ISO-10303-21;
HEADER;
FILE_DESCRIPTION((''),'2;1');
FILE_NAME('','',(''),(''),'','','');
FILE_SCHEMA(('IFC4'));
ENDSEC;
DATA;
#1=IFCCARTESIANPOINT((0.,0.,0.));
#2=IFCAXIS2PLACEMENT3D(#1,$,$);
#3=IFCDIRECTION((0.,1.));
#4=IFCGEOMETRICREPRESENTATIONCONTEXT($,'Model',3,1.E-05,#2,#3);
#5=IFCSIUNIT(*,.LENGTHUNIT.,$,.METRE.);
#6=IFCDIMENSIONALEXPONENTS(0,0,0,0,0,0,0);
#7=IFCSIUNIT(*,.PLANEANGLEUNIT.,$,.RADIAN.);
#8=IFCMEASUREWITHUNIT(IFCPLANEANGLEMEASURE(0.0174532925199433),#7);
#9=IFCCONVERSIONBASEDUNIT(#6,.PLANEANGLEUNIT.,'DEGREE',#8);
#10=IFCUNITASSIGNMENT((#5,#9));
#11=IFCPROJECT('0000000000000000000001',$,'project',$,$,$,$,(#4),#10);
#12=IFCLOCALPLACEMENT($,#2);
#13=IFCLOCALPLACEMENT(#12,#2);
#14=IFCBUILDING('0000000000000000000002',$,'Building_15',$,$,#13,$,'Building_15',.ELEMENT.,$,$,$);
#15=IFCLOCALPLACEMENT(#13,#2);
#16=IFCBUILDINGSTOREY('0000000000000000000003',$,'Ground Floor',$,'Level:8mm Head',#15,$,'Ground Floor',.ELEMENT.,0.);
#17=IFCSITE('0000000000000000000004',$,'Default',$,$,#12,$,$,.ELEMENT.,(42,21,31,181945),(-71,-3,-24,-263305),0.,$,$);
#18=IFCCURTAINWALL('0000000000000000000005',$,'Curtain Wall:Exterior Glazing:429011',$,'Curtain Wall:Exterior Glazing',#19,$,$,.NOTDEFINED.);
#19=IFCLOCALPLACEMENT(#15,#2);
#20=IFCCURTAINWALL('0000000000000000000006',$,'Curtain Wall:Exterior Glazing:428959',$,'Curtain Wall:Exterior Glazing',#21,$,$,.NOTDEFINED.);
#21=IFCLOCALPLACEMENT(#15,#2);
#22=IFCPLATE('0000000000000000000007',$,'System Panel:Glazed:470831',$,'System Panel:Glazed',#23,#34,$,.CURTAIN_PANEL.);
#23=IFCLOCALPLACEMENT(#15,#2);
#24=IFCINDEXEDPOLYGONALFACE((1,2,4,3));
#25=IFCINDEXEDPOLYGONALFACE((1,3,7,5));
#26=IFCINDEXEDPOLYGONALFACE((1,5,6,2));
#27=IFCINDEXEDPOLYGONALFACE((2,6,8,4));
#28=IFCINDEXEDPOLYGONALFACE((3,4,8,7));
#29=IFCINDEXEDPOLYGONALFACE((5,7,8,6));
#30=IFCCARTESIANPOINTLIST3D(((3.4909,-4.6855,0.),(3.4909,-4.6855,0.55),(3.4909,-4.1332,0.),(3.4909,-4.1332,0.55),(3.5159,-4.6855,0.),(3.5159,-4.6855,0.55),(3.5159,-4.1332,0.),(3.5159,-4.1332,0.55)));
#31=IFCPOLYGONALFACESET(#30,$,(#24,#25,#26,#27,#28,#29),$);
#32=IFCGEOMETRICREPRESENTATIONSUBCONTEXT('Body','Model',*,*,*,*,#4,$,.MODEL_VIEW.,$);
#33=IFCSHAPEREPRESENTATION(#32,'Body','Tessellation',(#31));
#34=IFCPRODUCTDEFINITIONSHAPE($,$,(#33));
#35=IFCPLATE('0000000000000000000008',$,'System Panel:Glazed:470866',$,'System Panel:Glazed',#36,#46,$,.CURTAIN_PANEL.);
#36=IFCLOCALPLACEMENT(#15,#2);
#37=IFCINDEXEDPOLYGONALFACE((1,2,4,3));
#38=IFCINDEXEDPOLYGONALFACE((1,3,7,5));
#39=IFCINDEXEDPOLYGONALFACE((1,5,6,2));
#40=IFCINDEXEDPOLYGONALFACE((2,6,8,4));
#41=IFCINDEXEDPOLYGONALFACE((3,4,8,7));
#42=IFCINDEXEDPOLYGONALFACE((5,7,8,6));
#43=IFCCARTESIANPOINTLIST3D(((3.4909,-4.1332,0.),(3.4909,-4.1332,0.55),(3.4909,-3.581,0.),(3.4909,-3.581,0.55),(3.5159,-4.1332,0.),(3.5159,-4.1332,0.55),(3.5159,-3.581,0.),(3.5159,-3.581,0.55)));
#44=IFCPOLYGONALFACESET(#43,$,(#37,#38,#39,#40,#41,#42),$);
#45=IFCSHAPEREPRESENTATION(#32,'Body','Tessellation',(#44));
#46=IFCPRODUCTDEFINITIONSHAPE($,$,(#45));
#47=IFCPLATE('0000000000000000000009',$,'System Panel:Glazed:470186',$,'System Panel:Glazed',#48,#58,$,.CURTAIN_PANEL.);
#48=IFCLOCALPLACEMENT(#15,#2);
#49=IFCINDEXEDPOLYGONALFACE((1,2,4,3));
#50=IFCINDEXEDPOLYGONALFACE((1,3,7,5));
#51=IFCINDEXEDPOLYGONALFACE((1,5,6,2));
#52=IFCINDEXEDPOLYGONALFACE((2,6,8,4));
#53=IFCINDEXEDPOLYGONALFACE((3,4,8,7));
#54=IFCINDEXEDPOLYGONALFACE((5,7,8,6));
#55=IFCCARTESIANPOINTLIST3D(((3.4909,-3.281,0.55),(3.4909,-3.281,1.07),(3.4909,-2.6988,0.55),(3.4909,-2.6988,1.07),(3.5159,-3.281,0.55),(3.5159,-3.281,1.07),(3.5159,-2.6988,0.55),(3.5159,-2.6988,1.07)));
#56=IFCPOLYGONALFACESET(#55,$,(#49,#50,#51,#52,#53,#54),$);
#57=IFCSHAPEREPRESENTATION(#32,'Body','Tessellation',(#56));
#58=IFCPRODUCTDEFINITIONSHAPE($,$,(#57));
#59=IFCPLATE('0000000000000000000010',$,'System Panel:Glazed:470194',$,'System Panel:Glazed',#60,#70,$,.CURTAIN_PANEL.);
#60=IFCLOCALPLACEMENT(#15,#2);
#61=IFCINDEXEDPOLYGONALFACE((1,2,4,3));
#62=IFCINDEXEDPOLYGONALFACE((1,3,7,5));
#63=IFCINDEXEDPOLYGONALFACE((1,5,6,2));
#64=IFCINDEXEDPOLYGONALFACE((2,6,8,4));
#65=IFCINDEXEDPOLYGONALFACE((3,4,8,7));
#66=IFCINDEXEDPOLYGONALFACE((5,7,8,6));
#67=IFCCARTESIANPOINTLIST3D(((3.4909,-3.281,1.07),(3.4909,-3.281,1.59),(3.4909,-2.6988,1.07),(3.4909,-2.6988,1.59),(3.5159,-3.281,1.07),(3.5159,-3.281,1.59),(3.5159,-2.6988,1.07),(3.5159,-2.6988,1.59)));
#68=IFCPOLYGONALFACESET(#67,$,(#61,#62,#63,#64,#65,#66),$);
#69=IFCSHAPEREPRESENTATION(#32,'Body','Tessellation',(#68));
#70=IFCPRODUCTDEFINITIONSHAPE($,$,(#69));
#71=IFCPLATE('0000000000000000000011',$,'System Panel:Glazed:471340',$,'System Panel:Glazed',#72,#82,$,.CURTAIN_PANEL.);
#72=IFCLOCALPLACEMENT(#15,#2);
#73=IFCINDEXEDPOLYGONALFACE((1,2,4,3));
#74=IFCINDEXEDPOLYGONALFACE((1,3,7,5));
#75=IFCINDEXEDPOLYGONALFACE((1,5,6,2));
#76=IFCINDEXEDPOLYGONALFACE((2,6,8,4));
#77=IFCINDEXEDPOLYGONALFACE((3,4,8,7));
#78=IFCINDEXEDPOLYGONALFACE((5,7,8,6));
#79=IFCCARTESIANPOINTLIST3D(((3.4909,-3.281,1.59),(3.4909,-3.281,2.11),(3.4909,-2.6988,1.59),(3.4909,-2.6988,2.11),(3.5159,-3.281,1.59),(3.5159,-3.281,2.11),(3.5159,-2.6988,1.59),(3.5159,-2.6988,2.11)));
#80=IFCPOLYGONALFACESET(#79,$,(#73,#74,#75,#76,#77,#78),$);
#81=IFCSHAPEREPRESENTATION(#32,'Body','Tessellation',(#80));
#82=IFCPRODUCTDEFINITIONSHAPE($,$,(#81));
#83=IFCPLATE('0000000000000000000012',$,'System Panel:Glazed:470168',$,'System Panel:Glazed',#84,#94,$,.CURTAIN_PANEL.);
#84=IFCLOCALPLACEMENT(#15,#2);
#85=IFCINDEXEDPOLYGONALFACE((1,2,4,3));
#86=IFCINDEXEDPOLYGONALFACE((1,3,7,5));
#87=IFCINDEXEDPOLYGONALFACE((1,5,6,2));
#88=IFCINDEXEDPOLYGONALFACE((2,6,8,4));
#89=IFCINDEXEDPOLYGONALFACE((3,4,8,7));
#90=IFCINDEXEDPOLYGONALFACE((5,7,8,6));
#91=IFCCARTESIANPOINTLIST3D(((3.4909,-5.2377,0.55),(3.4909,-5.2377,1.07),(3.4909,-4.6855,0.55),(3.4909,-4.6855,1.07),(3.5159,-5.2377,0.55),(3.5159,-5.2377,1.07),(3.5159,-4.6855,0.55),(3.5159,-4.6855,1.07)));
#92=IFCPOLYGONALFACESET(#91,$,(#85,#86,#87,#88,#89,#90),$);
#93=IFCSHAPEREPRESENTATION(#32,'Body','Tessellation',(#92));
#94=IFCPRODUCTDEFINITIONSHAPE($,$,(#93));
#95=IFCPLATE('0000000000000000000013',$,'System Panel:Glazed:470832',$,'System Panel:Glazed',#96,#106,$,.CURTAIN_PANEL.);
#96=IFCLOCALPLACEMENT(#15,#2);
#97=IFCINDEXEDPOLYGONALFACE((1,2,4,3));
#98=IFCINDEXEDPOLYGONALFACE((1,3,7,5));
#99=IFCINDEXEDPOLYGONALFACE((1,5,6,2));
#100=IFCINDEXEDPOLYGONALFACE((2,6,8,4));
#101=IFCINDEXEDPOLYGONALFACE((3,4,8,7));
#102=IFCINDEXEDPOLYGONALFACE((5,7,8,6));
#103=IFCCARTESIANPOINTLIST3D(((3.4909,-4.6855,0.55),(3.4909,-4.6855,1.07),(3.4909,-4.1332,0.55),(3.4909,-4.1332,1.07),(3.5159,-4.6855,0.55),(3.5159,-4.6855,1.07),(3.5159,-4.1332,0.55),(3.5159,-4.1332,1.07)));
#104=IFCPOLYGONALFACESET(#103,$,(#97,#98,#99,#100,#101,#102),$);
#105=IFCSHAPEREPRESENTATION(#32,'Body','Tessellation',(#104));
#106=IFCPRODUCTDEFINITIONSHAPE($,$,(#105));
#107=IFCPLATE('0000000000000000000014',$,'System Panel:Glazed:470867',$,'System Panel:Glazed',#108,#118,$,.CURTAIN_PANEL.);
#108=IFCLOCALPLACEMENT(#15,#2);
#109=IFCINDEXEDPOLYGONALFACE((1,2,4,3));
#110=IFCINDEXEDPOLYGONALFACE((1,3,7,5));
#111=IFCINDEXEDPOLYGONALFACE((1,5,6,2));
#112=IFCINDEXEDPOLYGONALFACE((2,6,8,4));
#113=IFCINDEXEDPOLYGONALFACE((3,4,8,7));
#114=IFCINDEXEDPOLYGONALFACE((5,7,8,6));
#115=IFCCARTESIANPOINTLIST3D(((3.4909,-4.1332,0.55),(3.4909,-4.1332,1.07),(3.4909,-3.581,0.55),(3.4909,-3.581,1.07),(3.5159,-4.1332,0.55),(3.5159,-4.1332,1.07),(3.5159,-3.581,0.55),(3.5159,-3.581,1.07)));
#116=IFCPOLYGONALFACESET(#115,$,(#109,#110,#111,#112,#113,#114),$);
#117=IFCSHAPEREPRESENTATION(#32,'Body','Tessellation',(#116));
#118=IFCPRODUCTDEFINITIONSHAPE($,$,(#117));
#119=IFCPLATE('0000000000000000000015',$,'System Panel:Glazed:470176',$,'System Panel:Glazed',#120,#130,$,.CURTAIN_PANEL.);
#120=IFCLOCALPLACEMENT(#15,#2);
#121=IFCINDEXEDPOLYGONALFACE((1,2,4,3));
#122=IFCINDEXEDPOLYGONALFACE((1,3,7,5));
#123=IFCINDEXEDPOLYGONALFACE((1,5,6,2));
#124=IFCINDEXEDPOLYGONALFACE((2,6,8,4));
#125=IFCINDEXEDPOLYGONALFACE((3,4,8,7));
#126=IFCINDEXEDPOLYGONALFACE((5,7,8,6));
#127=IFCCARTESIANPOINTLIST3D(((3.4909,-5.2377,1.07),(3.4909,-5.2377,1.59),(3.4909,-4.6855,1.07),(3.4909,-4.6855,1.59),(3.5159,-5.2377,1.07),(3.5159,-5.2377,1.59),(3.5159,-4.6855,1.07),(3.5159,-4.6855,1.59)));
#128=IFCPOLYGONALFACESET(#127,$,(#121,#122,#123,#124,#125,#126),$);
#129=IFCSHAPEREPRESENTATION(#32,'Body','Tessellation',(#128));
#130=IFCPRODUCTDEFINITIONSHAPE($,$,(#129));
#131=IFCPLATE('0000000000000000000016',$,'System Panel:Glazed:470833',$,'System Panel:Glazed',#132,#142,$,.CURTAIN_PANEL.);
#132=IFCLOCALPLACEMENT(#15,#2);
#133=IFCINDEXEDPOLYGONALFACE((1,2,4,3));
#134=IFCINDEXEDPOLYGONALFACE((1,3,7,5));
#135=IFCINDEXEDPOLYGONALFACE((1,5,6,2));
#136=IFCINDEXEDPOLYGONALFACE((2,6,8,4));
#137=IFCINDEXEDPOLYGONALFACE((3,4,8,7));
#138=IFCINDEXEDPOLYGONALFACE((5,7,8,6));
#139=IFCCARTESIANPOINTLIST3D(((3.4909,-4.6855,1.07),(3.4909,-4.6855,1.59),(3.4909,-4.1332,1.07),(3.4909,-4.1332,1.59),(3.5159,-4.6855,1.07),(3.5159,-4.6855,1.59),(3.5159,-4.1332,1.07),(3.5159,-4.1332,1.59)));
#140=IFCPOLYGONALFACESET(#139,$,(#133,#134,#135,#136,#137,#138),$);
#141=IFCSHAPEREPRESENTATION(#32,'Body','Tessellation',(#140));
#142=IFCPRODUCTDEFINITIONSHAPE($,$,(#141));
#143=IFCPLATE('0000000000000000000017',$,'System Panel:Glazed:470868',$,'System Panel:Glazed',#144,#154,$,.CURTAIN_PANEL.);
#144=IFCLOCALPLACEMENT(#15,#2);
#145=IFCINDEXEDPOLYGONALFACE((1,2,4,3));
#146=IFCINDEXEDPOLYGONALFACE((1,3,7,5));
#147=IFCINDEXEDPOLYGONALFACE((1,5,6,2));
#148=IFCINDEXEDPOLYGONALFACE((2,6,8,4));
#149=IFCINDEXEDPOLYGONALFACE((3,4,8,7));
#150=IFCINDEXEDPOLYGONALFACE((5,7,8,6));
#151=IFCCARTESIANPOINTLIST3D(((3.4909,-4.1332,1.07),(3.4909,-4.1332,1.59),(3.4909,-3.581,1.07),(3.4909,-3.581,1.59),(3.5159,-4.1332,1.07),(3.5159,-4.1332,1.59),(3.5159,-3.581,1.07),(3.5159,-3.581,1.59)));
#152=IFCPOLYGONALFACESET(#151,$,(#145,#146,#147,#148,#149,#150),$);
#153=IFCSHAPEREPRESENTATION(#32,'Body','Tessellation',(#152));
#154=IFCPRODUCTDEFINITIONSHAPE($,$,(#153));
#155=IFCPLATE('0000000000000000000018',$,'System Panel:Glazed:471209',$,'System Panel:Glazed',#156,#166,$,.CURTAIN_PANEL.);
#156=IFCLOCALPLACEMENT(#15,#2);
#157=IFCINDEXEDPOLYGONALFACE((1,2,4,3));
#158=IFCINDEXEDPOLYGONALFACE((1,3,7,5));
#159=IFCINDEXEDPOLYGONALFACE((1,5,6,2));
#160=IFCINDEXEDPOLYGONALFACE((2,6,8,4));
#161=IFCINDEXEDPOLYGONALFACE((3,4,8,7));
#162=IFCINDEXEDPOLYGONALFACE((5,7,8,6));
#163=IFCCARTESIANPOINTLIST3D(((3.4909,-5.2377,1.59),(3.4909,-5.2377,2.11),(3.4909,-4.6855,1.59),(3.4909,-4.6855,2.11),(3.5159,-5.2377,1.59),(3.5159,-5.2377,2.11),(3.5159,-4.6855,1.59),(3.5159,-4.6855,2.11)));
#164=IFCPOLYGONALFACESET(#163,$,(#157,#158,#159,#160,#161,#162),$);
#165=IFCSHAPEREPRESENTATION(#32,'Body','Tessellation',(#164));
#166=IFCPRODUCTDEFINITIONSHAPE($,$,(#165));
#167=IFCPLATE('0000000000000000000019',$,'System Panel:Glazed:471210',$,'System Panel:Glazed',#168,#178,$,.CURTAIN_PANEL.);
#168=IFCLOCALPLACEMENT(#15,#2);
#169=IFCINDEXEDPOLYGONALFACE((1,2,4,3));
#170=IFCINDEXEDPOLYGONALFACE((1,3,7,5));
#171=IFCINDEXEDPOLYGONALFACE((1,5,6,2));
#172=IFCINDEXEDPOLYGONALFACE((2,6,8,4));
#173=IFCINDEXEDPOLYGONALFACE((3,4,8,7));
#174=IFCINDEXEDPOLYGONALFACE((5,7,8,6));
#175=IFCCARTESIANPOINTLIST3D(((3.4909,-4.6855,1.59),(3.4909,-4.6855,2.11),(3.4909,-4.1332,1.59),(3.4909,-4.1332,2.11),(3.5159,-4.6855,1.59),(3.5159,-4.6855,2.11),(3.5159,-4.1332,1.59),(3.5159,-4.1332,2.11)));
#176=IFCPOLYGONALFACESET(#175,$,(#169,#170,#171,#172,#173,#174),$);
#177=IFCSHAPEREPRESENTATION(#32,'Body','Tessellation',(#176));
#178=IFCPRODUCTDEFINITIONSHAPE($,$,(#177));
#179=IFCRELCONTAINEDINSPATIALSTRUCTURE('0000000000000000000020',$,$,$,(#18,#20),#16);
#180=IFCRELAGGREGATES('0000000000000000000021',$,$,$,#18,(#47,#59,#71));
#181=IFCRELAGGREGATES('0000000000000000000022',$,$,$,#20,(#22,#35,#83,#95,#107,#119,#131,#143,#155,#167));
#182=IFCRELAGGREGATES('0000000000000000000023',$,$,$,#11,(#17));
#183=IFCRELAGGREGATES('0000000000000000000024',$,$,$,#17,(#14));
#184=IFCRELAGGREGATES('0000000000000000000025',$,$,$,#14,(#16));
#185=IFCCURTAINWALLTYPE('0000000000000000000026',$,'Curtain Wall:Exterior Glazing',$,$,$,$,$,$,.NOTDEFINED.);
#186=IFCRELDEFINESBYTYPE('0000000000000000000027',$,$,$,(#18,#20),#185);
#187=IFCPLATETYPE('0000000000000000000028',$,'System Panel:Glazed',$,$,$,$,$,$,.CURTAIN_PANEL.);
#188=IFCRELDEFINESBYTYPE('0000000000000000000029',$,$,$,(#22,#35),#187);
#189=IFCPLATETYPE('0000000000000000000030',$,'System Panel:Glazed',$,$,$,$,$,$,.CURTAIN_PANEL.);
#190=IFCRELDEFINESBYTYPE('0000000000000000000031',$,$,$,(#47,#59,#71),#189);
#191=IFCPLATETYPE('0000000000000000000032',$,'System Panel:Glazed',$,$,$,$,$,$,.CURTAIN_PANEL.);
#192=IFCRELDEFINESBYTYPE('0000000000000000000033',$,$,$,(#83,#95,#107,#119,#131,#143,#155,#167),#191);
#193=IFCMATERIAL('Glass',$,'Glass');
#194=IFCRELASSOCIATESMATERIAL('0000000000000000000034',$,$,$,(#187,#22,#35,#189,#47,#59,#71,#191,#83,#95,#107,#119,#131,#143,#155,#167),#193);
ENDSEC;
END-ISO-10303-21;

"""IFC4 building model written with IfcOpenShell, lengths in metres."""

from ifc_helpers import new_model, entity, si_unit, converted_unit, direction, frame, origin, place, context, subcontext, project, spatial, indexed_curve, outline, extrude, source, transform, mapped, material, type_object, type_shapes, element, aggregate, save


model = new_model("IFC4")

# Units and contexts
model_context = context("Model", 3, precision=1e-05, world=origin(), true_north=direction((0.0, 1.0)))
body_context = subcontext(model_context, "Body", "Model", "MODEL_VIEW")
ifc_project = project(units=[si_unit("LENGTHUNIT", "METRE"), converted_unit("PLANEANGLEUNIT", "DEGREE", entity("IfcPlaneAngleMeasure", 0.0174532925199433), si_unit("PLANEANGLEUNIT", "RADIAN"), dimensions=[0, 0, 0, 0, 0, 0, 0])], contexts=[model_context])

# Site, building, storey
site_placement = place(None, origin())
site = spatial("IfcSite", under=ifc_project, at=site_placement, Name="Default", CompositionType="ELEMENT", RefLatitude=(42, 21, 31, 181945), RefLongitude=(-71, -3, -24, -263305), RefElevation=0.0)
building_placement = place(site_placement, origin())
building = spatial("IfcBuilding", under=site, at=building_placement, Name="Building_15", LongName="Building_15", CompositionType="ELEMENT")
storey_placement = place(building_placement, origin())
storey = spatial("IfcBuildingStorey", under=building, at=storey_placement, Name="Ground Floor", ObjectType="Level:8mm Head", LongName="Ground Floor", CompositionType="ELEMENT", Elevation=0.0)

# Curtain walls
curtain_wall_type = type_object("IfcCurtainWallType", Name="Curtain Wall:Exterior Glazing", PredefinedType="NOTDEFINED")
curtain_wall_1_placement = place(storey_placement, origin())
curtain_wall_1 = element("IfcCurtainWall", 1, at=curtain_wall_1_placement, inside=storey, type_object=curtain_wall_type, Name="Curtain Wall:Exterior Glazing:429011", ObjectType="Curtain Wall:Exterior Glazing", PredefinedType="NOTDEFINED")
curtain_wall_2_placement = place(storey_placement, origin())
curtain_wall_2 = element("IfcCurtainWall", 2, at=curtain_wall_2_placement, inside=storey, type_object=curtain_wall_type, Name="Curtain Wall:Exterior Glazing:428959", ObjectType="Curtain Wall:Exterior Glazing", PredefinedType="NOTDEFINED")

# Plates
ifc_material_1 = material(Name="Glass", Category="Glass")
plate_type_1 = type_object("IfcPlateType", Name="System Panel:Glazed", PredefinedType="CURTAIN_PANEL", material=ifc_material_1)
shared_shape_1 = source(origin(), body_context, "Body", "SweptSolid", [
    extrude(outline(indexed_curve([(-0.0125, -0.2761), (0.0125, -0.2761), (0.0125, 0.2761), (-0.0125, 0.2761), (-0.0125, -0.2761)], self_intersect=False)), frame((0.0, 0.037, 0.0), z_axis=(0.0, 0.0, 1.0), x_axis=(0.0, 1.0, 0.0)), (0.0, 0.0, 1.0), 0.55),
])
type_shapes(plate_type_1, [shared_shape_1])
plate_1_placement = place(curtain_wall_2_placement, frame((3.5404, -4.4093, 0.0), z_axis=(0.0, 0.0, 1.0), x_axis=(0.0, 1.0, 0.0)))
plate_1 = element("IfcPlate", 3, at=plate_1_placement, type_object=plate_type_1, material=ifc_material_1, Name="System Panel:Glazed:470831", ObjectType="System Panel:Glazed", PredefinedType="CURTAIN_PANEL", context=body_context, shape_type="MappedRepresentation", body=[
    mapped(shared_shape_1, transform((0.0, 0.0, 0.0), scale=1.0)),
])
plate_2_placement = place(curtain_wall_2_placement, frame((3.5404, -3.8571, 0.0), z_axis=(0.0, 0.0, 1.0), x_axis=(0.0, 1.0, 0.0)))
plate_2 = element("IfcPlate", 4, at=plate_2_placement, type_object=plate_type_1, material=ifc_material_1, Name="System Panel:Glazed:470866", ObjectType="System Panel:Glazed", PredefinedType="CURTAIN_PANEL", context=body_context, shape_type="MappedRepresentation", body=[
    mapped(shared_shape_1, transform((0.0, 0.0, 0.0), scale=1.0)),
])
plate_type_2 = type_object("IfcPlateType", Name="System Panel:Glazed", PredefinedType="CURTAIN_PANEL", material=ifc_material_1)
shared_shape_2 = source(origin(), body_context, "Body", "SweptSolid", [
    extrude(outline(indexed_curve([(-0.0125, -0.2911), (0.0125, -0.2911), (0.0125, 0.2911), (-0.0125, 0.2911), (-0.0125, -0.2911)], self_intersect=False)), frame((0.0, 0.037, 0.0), z_axis=(0.0, 0.0, 1.0), x_axis=(0.0, 1.0, 0.0)), (0.0, 0.0, 1.0), 0.52),
])
type_shapes(plate_type_2, [shared_shape_2])
plate_3_placement = place(curtain_wall_1_placement, frame((3.5404, -2.9899, 0.55), z_axis=(0.0, 0.0, 1.0), x_axis=(0.0, 1.0, 0.0)))
plate_3 = element("IfcPlate", 5, at=plate_3_placement, type_object=plate_type_2, material=ifc_material_1, Name="System Panel:Glazed:470186", ObjectType="System Panel:Glazed", PredefinedType="CURTAIN_PANEL", context=body_context, shape_type="MappedRepresentation", body=[
    mapped(shared_shape_2, transform((0.0, 0.0, 0.0), scale=1.0)),
])
plate_4_placement = place(curtain_wall_1_placement, frame((3.5404, -2.9899, 1.07), z_axis=(0.0, 0.0, 1.0), x_axis=(0.0, 1.0, 0.0)))
plate_4 = element("IfcPlate", 6, at=plate_4_placement, type_object=plate_type_2, material=ifc_material_1, Name="System Panel:Glazed:470194", ObjectType="System Panel:Glazed", PredefinedType="CURTAIN_PANEL", context=body_context, shape_type="MappedRepresentation", body=[
    mapped(shared_shape_2, transform((0.0, 0.0, 0.0), scale=1.0)),
])
plate_5_placement = place(curtain_wall_1_placement, frame((3.5404, -2.9899, 1.59), z_axis=(0.0, 0.0, 1.0), x_axis=(0.0, 1.0, 0.0)))
plate_5 = element("IfcPlate", 7, at=plate_5_placement, type_object=plate_type_2, material=ifc_material_1, Name="System Panel:Glazed:471340", ObjectType="System Panel:Glazed", PredefinedType="CURTAIN_PANEL", context=body_context, shape_type="MappedRepresentation", body=[
    mapped(shared_shape_2, transform((0.0, 0.0, 0.0), scale=1.0)),
])
aggregate(curtain_wall_1, [plate_3, plate_4, plate_5])
plate_type_3 = type_object("IfcPlateType", Name="System Panel:Glazed", PredefinedType="CURTAIN_PANEL", material=ifc_material_1)
shared_shape_3 = source(origin(), body_context, "Body", "SweptSolid", [
    extrude(outline(indexed_curve([(-0.0125, -0.2761), (0.0125, -0.2761), (0.0125, 0.2761), (-0.0125, 0.2761), (-0.0125, -0.2761)], self_intersect=False)), frame((0.0, 0.037, 0.0), z_axis=(0.0, 0.0, 1.0), x_axis=(0.0, 1.0, 0.0)), (0.0, 0.0, 1.0), 0.52),
])
type_shapes(plate_type_3, [shared_shape_3])
plate_6_placement = place(curtain_wall_2_placement, frame((3.5404, -4.9616, 0.55), z_axis=(0.0, 0.0, 1.0), x_axis=(0.0, 1.0, 0.0)))
plate_6 = element("IfcPlate", 8, at=plate_6_placement, type_object=plate_type_3, material=ifc_material_1, Name="System Panel:Glazed:470168", ObjectType="System Panel:Glazed", PredefinedType="CURTAIN_PANEL", context=body_context, shape_type="MappedRepresentation", body=[
    mapped(shared_shape_3, transform((0.0, 0.0, 0.0), scale=1.0)),
])
plate_7_placement = place(curtain_wall_2_placement, frame((3.5404, -4.4093, 0.55), z_axis=(0.0, 0.0, 1.0), x_axis=(0.0, 1.0, 0.0)))
plate_7 = element("IfcPlate", 9, at=plate_7_placement, type_object=plate_type_3, material=ifc_material_1, Name="System Panel:Glazed:470832", ObjectType="System Panel:Glazed", PredefinedType="CURTAIN_PANEL", context=body_context, shape_type="MappedRepresentation", body=[
    mapped(shared_shape_3, transform((0.0, 0.0, 0.0), scale=1.0)),
])
plate_8_placement = place(curtain_wall_2_placement, frame((3.5404, -3.8571, 0.55), z_axis=(0.0, 0.0, 1.0), x_axis=(0.0, 1.0, 0.0)))
plate_8 = element("IfcPlate", 10, at=plate_8_placement, type_object=plate_type_3, material=ifc_material_1, Name="System Panel:Glazed:470867", ObjectType="System Panel:Glazed", PredefinedType="CURTAIN_PANEL", context=body_context, shape_type="MappedRepresentation", body=[
    mapped(shared_shape_3, transform((0.0, 0.0, 0.0), scale=1.0)),
])
plate_9_placement = place(curtain_wall_2_placement, frame((3.5404, -4.9616, 1.07), z_axis=(0.0, 0.0, 1.0), x_axis=(0.0, 1.0, 0.0)))
plate_9 = element("IfcPlate", 11, at=plate_9_placement, type_object=plate_type_3, material=ifc_material_1, Name="System Panel:Glazed:470176", ObjectType="System Panel:Glazed", PredefinedType="CURTAIN_PANEL", context=body_context, shape_type="MappedRepresentation", body=[
    mapped(shared_shape_3, transform((0.0, 0.0, 0.0), scale=1.0)),
])
plate_10_placement = place(curtain_wall_2_placement, frame((3.5404, -4.4093, 1.07), z_axis=(0.0, 0.0, 1.0), x_axis=(0.0, 1.0, 0.0)))
plate_10 = element("IfcPlate", 12, at=plate_10_placement, type_object=plate_type_3, material=ifc_material_1, Name="System Panel:Glazed:470833", ObjectType="System Panel:Glazed", PredefinedType="CURTAIN_PANEL", context=body_context, shape_type="MappedRepresentation", body=[
    mapped(shared_shape_3, transform((0.0, 0.0, 0.0), scale=1.0)),
])
plate_11_placement = place(curtain_wall_2_placement, frame((3.5404, -3.8571, 1.07), z_axis=(0.0, 0.0, 1.0), x_axis=(0.0, 1.0, 0.0)))
plate_11 = element("IfcPlate", 13, at=plate_11_placement, type_object=plate_type_3, material=ifc_material_1, Name="System Panel:Glazed:470868", ObjectType="System Panel:Glazed", PredefinedType="CURTAIN_PANEL", context=body_context, shape_type="MappedRepresentation", body=[
    mapped(shared_shape_3, transform((0.0, 0.0, 0.0), scale=1.0)),
])
plate_12_placement = place(curtain_wall_2_placement, frame((3.5404, -4.9616, 1.59), z_axis=(0.0, 0.0, 1.0), x_axis=(0.0, 1.0, 0.0)))
plate_12 = element("IfcPlate", 14, at=plate_12_placement, type_object=plate_type_3, material=ifc_material_1, Name="System Panel:Glazed:471209", ObjectType="System Panel:Glazed", PredefinedType="CURTAIN_PANEL", context=body_context, shape_type="MappedRepresentation", body=[
    mapped(shared_shape_3, transform((0.0, 0.0, 0.0), scale=1.0)),
])
plate_13_placement = place(curtain_wall_2_placement, frame((3.5404, -4.4093, 1.59), z_axis=(0.0, 0.0, 1.0), x_axis=(0.0, 1.0, 0.0)))
plate_13 = element("IfcPlate", 15, at=plate_13_placement, type_object=plate_type_3, material=ifc_material_1, Name="System Panel:Glazed:471210", ObjectType="System Panel:Glazed", PredefinedType="CURTAIN_PANEL", context=body_context, shape_type="MappedRepresentation", body=[
    mapped(shared_shape_3, transform((0.0, 0.0, 0.0), scale=1.0)),
])
aggregate(curtain_wall_2, [plate_1, plate_2, plate_6, plate_7, plate_8, plate_9, plate_10, plate_11, plate_12, plate_13])

save(model, "model.ifc")
